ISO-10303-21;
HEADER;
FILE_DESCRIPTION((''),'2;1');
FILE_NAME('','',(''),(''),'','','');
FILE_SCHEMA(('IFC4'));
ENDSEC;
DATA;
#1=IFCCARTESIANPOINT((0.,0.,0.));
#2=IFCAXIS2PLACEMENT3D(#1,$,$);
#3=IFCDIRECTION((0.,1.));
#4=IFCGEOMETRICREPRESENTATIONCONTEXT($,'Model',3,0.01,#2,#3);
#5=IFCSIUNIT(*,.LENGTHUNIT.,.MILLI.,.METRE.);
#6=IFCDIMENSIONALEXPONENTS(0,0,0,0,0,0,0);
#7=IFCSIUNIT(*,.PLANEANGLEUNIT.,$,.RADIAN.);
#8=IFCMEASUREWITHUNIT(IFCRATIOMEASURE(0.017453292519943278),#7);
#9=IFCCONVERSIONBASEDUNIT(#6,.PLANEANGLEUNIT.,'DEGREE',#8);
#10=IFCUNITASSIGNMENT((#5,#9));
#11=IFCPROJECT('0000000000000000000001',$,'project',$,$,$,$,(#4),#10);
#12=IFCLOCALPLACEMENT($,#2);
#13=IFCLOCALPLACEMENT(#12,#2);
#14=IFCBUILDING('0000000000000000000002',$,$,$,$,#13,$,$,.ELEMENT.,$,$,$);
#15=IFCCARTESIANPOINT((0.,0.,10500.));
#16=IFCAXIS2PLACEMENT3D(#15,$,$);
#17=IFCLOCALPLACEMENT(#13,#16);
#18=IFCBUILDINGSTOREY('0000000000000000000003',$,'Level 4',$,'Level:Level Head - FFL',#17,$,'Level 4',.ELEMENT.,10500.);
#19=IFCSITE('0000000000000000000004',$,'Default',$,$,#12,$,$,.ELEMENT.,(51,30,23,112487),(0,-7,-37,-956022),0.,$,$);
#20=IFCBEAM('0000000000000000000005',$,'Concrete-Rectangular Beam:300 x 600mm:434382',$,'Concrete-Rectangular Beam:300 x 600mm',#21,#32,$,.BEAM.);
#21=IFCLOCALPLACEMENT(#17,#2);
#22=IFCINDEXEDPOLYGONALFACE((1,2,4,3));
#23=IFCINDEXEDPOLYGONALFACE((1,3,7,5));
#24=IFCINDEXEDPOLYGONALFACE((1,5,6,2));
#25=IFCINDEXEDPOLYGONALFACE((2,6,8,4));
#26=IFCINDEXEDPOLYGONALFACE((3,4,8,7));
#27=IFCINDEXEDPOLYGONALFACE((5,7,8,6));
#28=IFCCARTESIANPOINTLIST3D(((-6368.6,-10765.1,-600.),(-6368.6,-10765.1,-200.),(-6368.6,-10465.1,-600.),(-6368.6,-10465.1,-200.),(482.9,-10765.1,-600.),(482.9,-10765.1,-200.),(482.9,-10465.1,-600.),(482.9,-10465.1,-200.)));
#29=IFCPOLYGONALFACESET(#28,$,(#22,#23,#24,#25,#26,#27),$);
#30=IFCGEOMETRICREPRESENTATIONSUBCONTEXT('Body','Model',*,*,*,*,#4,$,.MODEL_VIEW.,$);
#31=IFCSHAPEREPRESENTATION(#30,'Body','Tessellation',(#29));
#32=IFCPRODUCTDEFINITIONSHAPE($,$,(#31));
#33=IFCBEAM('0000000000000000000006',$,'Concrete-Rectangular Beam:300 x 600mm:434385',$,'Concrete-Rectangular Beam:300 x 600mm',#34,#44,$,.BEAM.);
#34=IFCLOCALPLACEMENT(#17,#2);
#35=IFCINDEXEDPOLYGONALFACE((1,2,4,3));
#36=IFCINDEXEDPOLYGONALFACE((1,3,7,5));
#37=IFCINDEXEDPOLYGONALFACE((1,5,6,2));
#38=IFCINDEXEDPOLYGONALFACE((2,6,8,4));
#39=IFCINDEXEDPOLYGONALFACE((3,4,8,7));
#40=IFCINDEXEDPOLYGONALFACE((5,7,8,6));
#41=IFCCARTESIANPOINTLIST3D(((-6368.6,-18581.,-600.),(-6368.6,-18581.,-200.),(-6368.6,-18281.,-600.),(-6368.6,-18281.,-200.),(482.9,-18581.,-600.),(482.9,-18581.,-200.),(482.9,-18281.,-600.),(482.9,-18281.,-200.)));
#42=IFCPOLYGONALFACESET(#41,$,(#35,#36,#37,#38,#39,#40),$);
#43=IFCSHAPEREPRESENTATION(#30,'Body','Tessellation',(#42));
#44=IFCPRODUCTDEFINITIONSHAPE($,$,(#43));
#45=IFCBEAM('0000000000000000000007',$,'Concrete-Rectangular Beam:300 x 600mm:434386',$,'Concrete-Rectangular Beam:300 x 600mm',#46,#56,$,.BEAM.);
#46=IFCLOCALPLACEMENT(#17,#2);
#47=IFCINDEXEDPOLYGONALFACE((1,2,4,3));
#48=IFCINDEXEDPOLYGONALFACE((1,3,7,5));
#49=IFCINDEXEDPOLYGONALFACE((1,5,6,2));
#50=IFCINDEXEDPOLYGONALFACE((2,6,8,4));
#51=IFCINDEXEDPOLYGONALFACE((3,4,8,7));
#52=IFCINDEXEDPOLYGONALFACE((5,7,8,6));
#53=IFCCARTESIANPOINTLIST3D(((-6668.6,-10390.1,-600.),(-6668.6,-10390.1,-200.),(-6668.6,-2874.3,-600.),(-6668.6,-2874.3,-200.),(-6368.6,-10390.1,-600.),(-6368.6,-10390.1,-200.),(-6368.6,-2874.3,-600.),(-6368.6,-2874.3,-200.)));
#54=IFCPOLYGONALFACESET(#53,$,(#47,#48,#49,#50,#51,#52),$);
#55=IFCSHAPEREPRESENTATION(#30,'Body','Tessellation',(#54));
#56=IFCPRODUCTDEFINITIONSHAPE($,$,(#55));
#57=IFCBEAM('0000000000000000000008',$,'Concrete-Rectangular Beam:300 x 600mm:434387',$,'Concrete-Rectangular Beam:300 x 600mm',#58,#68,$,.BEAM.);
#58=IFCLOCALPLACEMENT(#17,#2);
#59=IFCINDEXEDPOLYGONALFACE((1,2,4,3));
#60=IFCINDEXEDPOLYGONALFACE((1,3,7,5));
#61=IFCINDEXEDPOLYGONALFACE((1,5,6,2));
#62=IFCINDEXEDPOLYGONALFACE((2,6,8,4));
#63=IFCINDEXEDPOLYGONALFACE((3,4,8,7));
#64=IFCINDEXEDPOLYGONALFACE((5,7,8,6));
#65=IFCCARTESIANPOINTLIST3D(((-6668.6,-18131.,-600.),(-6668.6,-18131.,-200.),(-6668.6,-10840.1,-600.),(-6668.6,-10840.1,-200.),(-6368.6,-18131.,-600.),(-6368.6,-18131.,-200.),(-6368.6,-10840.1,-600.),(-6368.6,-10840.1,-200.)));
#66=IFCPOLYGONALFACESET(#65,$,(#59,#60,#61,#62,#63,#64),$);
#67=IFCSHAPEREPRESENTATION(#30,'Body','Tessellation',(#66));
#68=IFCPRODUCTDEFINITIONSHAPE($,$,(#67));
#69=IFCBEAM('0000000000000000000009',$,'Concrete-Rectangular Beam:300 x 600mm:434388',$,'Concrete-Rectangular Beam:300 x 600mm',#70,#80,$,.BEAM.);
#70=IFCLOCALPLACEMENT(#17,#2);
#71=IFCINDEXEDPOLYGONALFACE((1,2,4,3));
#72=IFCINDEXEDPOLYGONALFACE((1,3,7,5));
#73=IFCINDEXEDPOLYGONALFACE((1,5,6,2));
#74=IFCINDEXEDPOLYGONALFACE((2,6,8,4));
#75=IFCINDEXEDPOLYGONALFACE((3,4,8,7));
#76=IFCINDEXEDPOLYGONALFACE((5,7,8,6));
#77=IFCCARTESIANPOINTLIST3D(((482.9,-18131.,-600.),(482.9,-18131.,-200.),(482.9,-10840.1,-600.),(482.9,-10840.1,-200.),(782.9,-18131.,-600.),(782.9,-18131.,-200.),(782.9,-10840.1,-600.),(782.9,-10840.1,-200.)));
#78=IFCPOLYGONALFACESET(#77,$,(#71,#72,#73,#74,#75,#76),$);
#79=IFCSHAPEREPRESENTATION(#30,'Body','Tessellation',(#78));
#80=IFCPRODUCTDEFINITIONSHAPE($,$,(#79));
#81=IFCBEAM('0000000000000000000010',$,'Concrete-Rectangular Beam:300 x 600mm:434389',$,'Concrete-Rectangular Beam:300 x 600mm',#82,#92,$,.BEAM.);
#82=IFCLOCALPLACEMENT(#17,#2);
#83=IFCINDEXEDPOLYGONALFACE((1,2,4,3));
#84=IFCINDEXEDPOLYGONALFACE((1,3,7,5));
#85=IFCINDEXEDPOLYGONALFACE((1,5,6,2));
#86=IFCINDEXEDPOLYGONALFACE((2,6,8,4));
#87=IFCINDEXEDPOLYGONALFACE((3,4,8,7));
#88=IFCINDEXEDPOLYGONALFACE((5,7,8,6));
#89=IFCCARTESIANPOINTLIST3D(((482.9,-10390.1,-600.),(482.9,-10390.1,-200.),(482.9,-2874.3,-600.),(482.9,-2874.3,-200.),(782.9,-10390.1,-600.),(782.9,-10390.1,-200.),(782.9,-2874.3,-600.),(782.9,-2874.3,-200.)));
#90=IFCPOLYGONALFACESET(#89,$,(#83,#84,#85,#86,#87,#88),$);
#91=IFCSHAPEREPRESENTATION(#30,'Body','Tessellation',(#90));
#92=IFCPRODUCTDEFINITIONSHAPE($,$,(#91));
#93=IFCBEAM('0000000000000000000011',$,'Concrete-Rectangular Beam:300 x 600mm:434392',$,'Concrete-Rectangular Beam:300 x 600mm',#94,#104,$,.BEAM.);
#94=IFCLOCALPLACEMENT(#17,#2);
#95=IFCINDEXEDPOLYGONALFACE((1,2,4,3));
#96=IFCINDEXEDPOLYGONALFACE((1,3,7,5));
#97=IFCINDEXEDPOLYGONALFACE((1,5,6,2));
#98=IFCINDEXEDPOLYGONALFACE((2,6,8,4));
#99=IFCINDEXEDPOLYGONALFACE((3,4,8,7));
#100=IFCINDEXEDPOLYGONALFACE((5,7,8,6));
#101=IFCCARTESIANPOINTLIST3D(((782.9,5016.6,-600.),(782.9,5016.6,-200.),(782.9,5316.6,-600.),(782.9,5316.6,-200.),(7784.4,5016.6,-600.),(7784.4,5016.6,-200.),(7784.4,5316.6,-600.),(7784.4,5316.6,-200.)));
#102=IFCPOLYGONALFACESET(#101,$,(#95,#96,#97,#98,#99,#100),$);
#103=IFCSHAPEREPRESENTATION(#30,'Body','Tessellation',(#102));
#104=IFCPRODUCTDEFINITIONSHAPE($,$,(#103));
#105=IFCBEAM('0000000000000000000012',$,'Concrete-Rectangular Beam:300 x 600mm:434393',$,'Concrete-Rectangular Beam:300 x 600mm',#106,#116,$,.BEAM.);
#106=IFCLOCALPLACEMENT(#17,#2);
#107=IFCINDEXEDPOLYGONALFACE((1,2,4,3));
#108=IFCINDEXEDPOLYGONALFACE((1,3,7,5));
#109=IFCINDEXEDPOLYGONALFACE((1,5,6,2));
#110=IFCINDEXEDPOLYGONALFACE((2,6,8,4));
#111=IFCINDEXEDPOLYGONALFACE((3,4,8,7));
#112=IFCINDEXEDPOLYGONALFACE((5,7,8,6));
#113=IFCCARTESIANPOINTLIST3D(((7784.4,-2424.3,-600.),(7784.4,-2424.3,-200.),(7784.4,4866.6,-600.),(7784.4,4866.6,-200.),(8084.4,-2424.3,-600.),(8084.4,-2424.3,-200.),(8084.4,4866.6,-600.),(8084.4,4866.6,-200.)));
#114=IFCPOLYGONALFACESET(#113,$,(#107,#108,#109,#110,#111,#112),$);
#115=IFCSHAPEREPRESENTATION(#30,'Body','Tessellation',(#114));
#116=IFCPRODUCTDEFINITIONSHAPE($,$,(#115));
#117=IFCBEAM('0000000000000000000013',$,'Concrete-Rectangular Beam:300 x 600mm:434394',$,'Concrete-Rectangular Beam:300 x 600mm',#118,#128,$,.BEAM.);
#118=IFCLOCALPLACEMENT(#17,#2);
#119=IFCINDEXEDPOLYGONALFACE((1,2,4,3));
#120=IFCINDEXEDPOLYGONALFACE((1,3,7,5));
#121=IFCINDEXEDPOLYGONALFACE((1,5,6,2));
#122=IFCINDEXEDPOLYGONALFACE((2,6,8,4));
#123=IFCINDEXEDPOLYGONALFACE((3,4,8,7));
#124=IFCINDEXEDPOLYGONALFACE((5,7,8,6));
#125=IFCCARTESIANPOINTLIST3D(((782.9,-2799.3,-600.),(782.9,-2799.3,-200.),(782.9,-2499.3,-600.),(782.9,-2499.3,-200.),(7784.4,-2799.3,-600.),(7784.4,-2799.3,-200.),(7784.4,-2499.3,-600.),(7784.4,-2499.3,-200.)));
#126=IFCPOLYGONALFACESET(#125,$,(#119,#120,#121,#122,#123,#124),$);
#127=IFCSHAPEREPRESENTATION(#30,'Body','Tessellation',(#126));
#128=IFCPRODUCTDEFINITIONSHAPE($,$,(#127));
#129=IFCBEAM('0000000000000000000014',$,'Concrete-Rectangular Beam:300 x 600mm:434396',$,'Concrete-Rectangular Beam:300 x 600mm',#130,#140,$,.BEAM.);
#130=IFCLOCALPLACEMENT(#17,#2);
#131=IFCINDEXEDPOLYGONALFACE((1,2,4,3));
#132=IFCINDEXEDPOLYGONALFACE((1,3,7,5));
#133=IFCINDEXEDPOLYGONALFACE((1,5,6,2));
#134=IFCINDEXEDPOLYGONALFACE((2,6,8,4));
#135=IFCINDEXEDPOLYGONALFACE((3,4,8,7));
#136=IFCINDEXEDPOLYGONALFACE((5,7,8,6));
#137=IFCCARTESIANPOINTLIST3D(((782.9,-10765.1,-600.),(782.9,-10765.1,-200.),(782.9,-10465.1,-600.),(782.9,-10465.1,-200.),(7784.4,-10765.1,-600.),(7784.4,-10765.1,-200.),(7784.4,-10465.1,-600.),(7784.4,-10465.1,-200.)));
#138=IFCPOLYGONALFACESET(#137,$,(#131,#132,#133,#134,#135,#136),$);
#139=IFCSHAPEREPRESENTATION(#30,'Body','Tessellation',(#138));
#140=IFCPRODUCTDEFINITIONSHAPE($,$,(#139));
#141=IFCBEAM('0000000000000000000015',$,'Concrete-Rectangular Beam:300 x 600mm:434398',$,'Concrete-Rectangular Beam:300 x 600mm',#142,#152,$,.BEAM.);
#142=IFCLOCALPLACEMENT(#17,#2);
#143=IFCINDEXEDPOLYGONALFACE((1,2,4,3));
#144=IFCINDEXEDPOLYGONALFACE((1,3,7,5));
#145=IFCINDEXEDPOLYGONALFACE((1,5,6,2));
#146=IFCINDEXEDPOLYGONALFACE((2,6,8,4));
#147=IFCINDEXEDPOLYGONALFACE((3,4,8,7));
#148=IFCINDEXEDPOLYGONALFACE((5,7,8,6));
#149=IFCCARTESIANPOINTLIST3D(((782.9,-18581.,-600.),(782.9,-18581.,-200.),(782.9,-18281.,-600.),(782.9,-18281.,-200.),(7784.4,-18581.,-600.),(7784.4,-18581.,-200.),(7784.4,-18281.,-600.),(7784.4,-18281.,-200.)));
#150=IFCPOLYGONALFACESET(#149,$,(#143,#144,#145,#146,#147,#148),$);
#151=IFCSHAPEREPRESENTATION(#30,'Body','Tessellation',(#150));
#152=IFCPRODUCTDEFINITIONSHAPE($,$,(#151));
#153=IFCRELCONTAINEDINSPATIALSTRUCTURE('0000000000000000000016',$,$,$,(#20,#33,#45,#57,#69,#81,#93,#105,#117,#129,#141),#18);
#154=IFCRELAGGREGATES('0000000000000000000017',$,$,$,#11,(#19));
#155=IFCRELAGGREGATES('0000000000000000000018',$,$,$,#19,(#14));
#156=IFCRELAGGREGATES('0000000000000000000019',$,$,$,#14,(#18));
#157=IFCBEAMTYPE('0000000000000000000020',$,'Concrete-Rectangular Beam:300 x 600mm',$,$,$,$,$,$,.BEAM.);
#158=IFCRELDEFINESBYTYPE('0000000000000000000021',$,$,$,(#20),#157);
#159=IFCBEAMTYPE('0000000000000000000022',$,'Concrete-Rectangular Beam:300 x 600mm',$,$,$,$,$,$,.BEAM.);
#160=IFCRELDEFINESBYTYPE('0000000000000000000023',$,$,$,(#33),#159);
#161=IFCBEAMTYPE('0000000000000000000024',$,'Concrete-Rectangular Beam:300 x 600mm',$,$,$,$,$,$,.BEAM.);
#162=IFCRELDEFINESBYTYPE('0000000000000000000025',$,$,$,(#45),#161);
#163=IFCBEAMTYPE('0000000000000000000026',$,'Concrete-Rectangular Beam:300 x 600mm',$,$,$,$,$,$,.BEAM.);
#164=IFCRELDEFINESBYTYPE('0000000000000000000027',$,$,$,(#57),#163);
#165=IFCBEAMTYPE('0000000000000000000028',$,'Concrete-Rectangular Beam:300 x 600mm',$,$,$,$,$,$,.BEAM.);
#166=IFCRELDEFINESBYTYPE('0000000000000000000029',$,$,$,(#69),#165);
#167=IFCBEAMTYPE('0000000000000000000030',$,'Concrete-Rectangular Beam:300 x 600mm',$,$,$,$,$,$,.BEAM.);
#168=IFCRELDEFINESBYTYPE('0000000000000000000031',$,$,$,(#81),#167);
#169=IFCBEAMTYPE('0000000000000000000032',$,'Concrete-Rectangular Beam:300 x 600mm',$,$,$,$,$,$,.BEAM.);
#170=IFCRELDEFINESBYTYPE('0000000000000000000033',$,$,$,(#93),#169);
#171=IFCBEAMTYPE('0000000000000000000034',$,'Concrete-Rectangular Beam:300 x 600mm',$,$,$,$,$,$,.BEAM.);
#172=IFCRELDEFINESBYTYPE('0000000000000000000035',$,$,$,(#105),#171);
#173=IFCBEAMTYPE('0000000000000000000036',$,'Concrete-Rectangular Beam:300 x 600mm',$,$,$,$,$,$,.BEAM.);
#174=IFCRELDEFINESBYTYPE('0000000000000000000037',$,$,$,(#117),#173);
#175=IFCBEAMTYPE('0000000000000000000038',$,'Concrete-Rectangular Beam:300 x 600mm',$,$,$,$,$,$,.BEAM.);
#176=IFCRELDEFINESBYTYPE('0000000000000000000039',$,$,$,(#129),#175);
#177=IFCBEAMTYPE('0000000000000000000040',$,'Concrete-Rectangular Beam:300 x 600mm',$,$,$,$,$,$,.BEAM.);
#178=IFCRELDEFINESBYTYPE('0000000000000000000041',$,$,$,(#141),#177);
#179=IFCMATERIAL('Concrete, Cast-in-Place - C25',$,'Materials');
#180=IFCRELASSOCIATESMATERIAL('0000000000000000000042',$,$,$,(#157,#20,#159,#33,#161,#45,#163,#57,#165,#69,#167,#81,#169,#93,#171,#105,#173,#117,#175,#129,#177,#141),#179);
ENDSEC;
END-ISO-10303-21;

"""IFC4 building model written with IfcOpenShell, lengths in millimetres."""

from ifc_helpers import new_model, entity, si_unit, converted_unit, direction, frame, origin, place, context, subcontext, project, spatial, indexed_curve, outline, extrude, source, transform, mapped, material, type_object, type_shapes, element, save


model = new_model("IFC4")

# Units and contexts
model_context = context("Model", 3, precision=0.01, world=origin(), true_north=direction((0.0, 1.0)))
body_context = subcontext(model_context, "Body", "Model", "MODEL_VIEW")
ifc_project = project(units=[si_unit("LENGTHUNIT", "METRE", prefix="MILLI"), converted_unit("PLANEANGLEUNIT", "DEGREE", entity("IfcRatioMeasure", 0.017453292519943278), si_unit("PLANEANGLEUNIT", "RADIAN"), dimensions=[0, 0, 0, 0, 0, 0, 0])], contexts=[model_context])

# Site, building, storey
site_placement = place(None, origin())
site = spatial("IfcSite", under=ifc_project, at=site_placement, Name="Default", CompositionType="ELEMENT", RefLatitude=(51, 30, 23, 112487), RefLongitude=(0, -7, -37, -956022), RefElevation=0.0)
building_placement = place(site_placement, origin())
building = spatial("IfcBuilding", under=site, at=building_placement, CompositionType="ELEMENT")
storey_placement = place(building_placement, frame((0.0, 0.0, 10500.0)))
storey = spatial("IfcBuildingStorey", under=building, at=storey_placement, Name="Level 4", ObjectType="Level:Level Head - FFL", LongName="Level 4", CompositionType="ELEMENT", Elevation=10500.0)

# Beams
ifc_material = material(Name="Concrete, Cast-in-Place - C25", Category="Materials")
beam_type_1 = type_object("IfcBeamType", Name="Concrete-Rectangular Beam:300 x 600mm", PredefinedType="BEAM", material=ifc_material)
shared_shape_1 = source(origin(), body_context, "Body", "SweptSolid", [
    extrude(outline(indexed_curve([(-200.0, -150.0), (200.0, -150.0), (200.0, 150.0), (-200.0, 150.0), (-200.0, -150.0)], self_intersect=False)), frame((482.9, -10615.1, 10100.0), z_axis=(-1.0, 0.0, 0.0), x_axis=(0.0, 0.0, -1.0)), (0.0, 0.0, 1.0), 6851.5),
])
type_shapes(beam_type_1, [shared_shape_1])
beam_1_placement = place(storey_placement, frame((0.0, 0.0, -10500.0)))
element("IfcBeam", 1, at=beam_1_placement, inside=storey, type_object=beam_type_1, material=ifc_material, Name="Concrete-Rectangular Beam:300 x 600mm:434382", ObjectType="Concrete-Rectangular Beam:300 x 600mm", PredefinedType="BEAM", context=body_context, shape_type="MappedRepresentation", body=[
    mapped(shared_shape_1, transform((0.0, 0.0, 0.0), scale=1.0)),
])
beam_type_2 = type_object("IfcBeamType", Name="Concrete-Rectangular Beam:300 x 600mm", PredefinedType="BEAM", material=ifc_material)
shared_shape_2 = source(origin(), body_context, "Body", "SweptSolid", [
    extrude(outline(indexed_curve([(-200.0, -150.0), (200.0, -150.0), (200.0, 150.0), (-200.0, 150.0), (-200.0, -150.0)], self_intersect=False)), frame((482.9, -18431.0, 10100.0), z_axis=(-1.0, 0.0, 0.0), x_axis=(0.0, 0.0, -1.0)), (0.0, 0.0, 1.0), 6851.5),
])
type_shapes(beam_type_2, [shared_shape_2])
beam_2_placement = place(storey_placement, frame((0.0, 0.0, -10500.0)))
element("IfcBeam", 2, at=beam_2_placement, inside=storey, type_object=beam_type_2, material=ifc_material, Name="Concrete-Rectangular Beam:300 x 600mm:434385", ObjectType="Concrete-Rectangular Beam:300 x 600mm", PredefinedType="BEAM", context=body_context, shape_type="MappedRepresentation", body=[
    mapped(shared_shape_2, transform((0.0, 0.0, 0.0), scale=1.0)),
])
beam_type_3 = type_object("IfcBeamType", Name="Concrete-Rectangular Beam:300 x 600mm", PredefinedType="BEAM", material=ifc_material)
shared_shape_3 = source(origin(), body_context, "Body", "SweptSolid", [
    extrude(outline(indexed_curve([(-150.0, -200.0), (150.0, -200.0), (150.0, 200.0), (-150.0, 200.0), (-150.0, -200.0)], self_intersect=False)), frame((-6518.6, -2874.3, 10100.0), z_axis=(0.0, -1.0, 0.0), x_axis=(-1.0, 0.0, 0.0)), (0.0, 0.0, 1.0), 7515.9),
])
type_shapes(beam_type_3, [shared_shape_3])
beam_3_placement = place(storey_placement, frame((0.0, 0.0, -10500.0)))
element("IfcBeam", 3, at=beam_3_placement, inside=storey, type_object=beam_type_3, material=ifc_material, Name="Concrete-Rectangular Beam:300 x 600mm:434386", ObjectType="Concrete-Rectangular Beam:300 x 600mm", PredefinedType="BEAM", context=body_context, shape_type="MappedRepresentation", body=[
    mapped(shared_shape_3, transform((0.0, 0.0, 0.0), scale=1.0)),
])
beam_type_4 = type_object("IfcBeamType", Name="Concrete-Rectangular Beam:300 x 600mm", PredefinedType="BEAM", material=ifc_material)
shared_shape_4 = source(origin(), body_context, "Body", "SweptSolid", [
    extrude(outline(indexed_curve([(-150.0, -200.0), (150.0, -200.0), (150.0, 200.0), (-150.0, 200.0), (-150.0, -200.0)], self_intersect=False)), frame((-6518.6, -10840.1, 10100.0), z_axis=(0.0, -1.0, 0.0), x_axis=(-1.0, 0.0, 0.0)), (0.0, 0.0, 1.0), 7290.9),
])
type_shapes(beam_type_4, [shared_shape_4])
beam_4_placement = place(storey_placement, frame((0.0, 0.0, -10500.0)))
element("IfcBeam", 4, at=beam_4_placement, inside=storey, type_object=beam_type_4, material=ifc_material, Name="Concrete-Rectangular Beam:300 x 600mm:434387", ObjectType="Concrete-Rectangular Beam:300 x 600mm", PredefinedType="BEAM", context=body_context, shape_type="MappedRepresentation", body=[
    mapped(shared_shape_4, transform((0.0, 0.0, 0.0), scale=1.0)),
])
beam_type_5 = type_object("IfcBeamType", Name="Concrete-Rectangular Beam:300 x 600mm", PredefinedType="BEAM", material=ifc_material)
shared_shape_5 = source(origin(), body_context, "Body", "SweptSolid", [
    extrude(outline(indexed_curve([(-150.0, -200.0), (150.0, -200.0), (150.0, 200.0), (-150.0, 200.0), (-150.0, -200.0)], self_intersect=False)), frame((632.9, -18131.0, 10100.0), z_axis=(0.0, 1.0, 0.0), x_axis=(-1.0, 0.0, 0.0)), (0.0, 0.0, 1.0), 7290.9),
])
type_shapes(beam_type_5, [shared_shape_5])
beam_5_placement = place(storey_placement, frame((0.0, 0.0, -10500.0)))
element("IfcBeam", 5, at=beam_5_placement, inside=storey, type_object=beam_type_5, material=ifc_material, Name="Concrete-Rectangular Beam:300 x 600mm:434388", ObjectType="Concrete-Rectangular Beam:300 x 600mm", PredefinedType="BEAM", context=body_context, shape_type="MappedRepresentation", body=[
    mapped(shared_shape_5, transform((0.0, 0.0, 0.0), scale=1.0)),
])
beam_type_6 = type_object("IfcBeamType", Name="Concrete-Rectangular Beam:300 x 600mm", PredefinedType="BEAM", material=ifc_material)
shared_shape_6 = source(origin(), body_context, "Body", "SweptSolid", [
    extrude(outline(indexed_curve([(-150.0, -200.0), (150.0, -200.0), (150.0, 200.0), (-150.0, 200.0), (-150.0, -200.0)], self_intersect=False)), frame((632.9, -10390.1, 10100.0), z_axis=(0.0, 1.0, 0.0), x_axis=(-1.0, 0.0, 0.0)), (0.0, 0.0, 1.0), 7515.9),
])
type_shapes(beam_type_6, [shared_shape_6])
beam_6_placement = place(storey_placement, frame((0.0, 0.0, -10500.0)))
element("IfcBeam", 6, at=beam_6_placement, inside=storey, type_object=beam_type_6, material=ifc_material, Name="Concrete-Rectangular Beam:300 x 600mm:434389", ObjectType="Concrete-Rectangular Beam:300 x 600mm", PredefinedType="BEAM", context=body_context, shape_type="MappedRepresentation", body=[
    mapped(shared_shape_6, transform((0.0, 0.0, 0.0), scale=1.0)),
])
beam_type_7 = type_object("IfcBeamType", Name="Concrete-Rectangular Beam:300 x 600mm", PredefinedType="BEAM", material=ifc_material)
shared_shape_7 = source(origin(), body_context, "Body", "SweptSolid", [
    extrude(outline(indexed_curve([(-200.0, -150.0), (200.0, -150.0), (200.0, 150.0), (-200.0, 150.0), (-200.0, -150.0)], self_intersect=False)), frame((782.9, 5166.6, 10100.0), z_axis=(1.0, 0.0, 0.0), x_axis=(0.0, 0.0, -1.0)), (0.0, 0.0, 1.0), 7001.5),
])
type_shapes(beam_type_7, [shared_shape_7])
beam_7_placement = place(storey_placement, frame((0.0, 0.0, -10500.0)))
element("IfcBeam", 7, at=beam_7_placement, inside=storey, type_object=beam_type_7, material=ifc_material, Name="Concrete-Rectangular Beam:300 x 600mm:434392", ObjectType="Concrete-Rectangular Beam:300 x 600mm", PredefinedType="BEAM", context=body_context, shape_type="MappedRepresentation", body=[
    mapped(shared_shape_7, transform((0.0, 0.0, 0.0), scale=1.0)),
])
beam_type_8 = type_object("IfcBeamType", Name="Concrete-Rectangular Beam:300 x 600mm", PredefinedType="BEAM", material=ifc_material)
shared_shape_8 = source(origin(), body_context, "Body", "SweptSolid", [
    extrude(outline(indexed_curve([(-150.0, -200.0), (150.0, -200.0), (150.0, 200.0), (-150.0, 200.0), (-150.0, -200.0)], self_intersect=False)), frame((7934.4, 4866.6, 10100.0), z_axis=(0.0, -1.0, 0.0), x_axis=(-1.0, 0.0, 0.0)), (0.0, 0.0, 1.0), 7290.9),
])
type_shapes(beam_type_8, [shared_shape_8])
beam_8_placement = place(storey_placement, frame((0.0, 0.0, -10500.0)))
element("IfcBeam", 8, at=beam_8_placement, inside=storey, type_object=beam_type_8, material=ifc_material, Name="Concrete-Rectangular Beam:300 x 600mm:434393", ObjectType="Concrete-Rectangular Beam:300 x 600mm", PredefinedType="BEAM", context=body_context, shape_type="MappedRepresentation", body=[
    mapped(shared_shape_8, transform((0.0, 0.0, 0.0), scale=1.0)),
])
beam_type_9 = type_object("IfcBeamType", Name="Concrete-Rectangular Beam:300 x 600mm", PredefinedType="BEAM", material=ifc_material)
shared_shape_9 = source(origin(), body_context, "Body", "SweptSolid", [
    extrude(outline(indexed_curve([(-200.0, -150.0), (200.0, -150.0), (200.0, 150.0), (-200.0, 150.0), (-200.0, -150.0)], self_intersect=False)), frame((7784.4, -2649.3, 10100.0), z_axis=(-1.0, 0.0, 0.0), x_axis=(0.0, 0.0, -1.0)), (0.0, 0.0, 1.0), 7001.5),
])
type_shapes(beam_type_9, [shared_shape_9])
beam_9_placement = place(storey_placement, frame((0.0, 0.0, -10500.0)))
element("IfcBeam", 9, at=beam_9_placement, inside=storey, type_object=beam_type_9, material=ifc_material, Name="Concrete-Rectangular Beam:300 x 600mm:434394", ObjectType="Concrete-Rectangular Beam:300 x 600mm", PredefinedType="BEAM", context=body_context, shape_type="MappedRepresentation", body=[
    mapped(shared_shape_9, transform((0.0, 0.0, 0.0), scale=1.0)),
])
beam_type_10 = type_object("IfcBeamType", Name="Concrete-Rectangular Beam:300 x 600mm", PredefinedType="BEAM", material=ifc_material)
shared_shape_10 = source(origin(), body_context, "Body", "SweptSolid", [
    extrude(outline(indexed_curve([(-200.0, -150.0), (200.0, -150.0), (200.0, 150.0), (-200.0, 150.0), (-200.0, -150.0)], self_intersect=False)), frame((7784.4, -10615.1, 10100.0), z_axis=(-1.0, 0.0, 0.0), x_axis=(0.0, 0.0, -1.0)), (0.0, 0.0, 1.0), 7001.5),
])
type_shapes(beam_type_10, [shared_shape_10])
beam_10_placement = place(storey_placement, frame((0.0, 0.0, -10500.0)))
element("IfcBeam", 10, at=beam_10_placement, inside=storey, type_object=beam_type_10, material=ifc_material, Name="Concrete-Rectangular Beam:300 x 600mm:434396", ObjectType="Concrete-Rectangular Beam:300 x 600mm", PredefinedType="BEAM", context=body_context, shape_type="MappedRepresentation", body=[
    mapped(shared_shape_10, transform((0.0, 0.0, 0.0), scale=1.0)),
])
beam_type_11 = type_object("IfcBeamType", Name="Concrete-Rectangular Beam:300 x 600mm", PredefinedType="BEAM", material=ifc_material)
shared_shape_11 = source(origin(), body_context, "Body", "SweptSolid", [
    extrude(outline(indexed_curve([(-200.0, -150.0), (200.0, -150.0), (200.0, 150.0), (-200.0, 150.0), (-200.0, -150.0)], self_intersect=False)), frame((7784.4, -18431.0, 10100.0), z_axis=(-1.0, 0.0, 0.0), x_axis=(0.0, 0.0, -1.0)), (0.0, 0.0, 1.0), 7001.5),
])
type_shapes(beam_type_11, [shared_shape_11])
beam_11_placement = place(storey_placement, frame((0.0, 0.0, -10500.0)))
element("IfcBeam", 11, at=beam_11_placement, inside=storey, type_object=beam_type_11, material=ifc_material, Name="Concrete-Rectangular Beam:300 x 600mm:434398", ObjectType="Concrete-Rectangular Beam:300 x 600mm", PredefinedType="BEAM", context=body_context, shape_type="MappedRepresentation", body=[
    mapped(shared_shape_11, transform((0.0, 0.0, 0.0), scale=1.0)),
])

save(model, "model.ifc")
